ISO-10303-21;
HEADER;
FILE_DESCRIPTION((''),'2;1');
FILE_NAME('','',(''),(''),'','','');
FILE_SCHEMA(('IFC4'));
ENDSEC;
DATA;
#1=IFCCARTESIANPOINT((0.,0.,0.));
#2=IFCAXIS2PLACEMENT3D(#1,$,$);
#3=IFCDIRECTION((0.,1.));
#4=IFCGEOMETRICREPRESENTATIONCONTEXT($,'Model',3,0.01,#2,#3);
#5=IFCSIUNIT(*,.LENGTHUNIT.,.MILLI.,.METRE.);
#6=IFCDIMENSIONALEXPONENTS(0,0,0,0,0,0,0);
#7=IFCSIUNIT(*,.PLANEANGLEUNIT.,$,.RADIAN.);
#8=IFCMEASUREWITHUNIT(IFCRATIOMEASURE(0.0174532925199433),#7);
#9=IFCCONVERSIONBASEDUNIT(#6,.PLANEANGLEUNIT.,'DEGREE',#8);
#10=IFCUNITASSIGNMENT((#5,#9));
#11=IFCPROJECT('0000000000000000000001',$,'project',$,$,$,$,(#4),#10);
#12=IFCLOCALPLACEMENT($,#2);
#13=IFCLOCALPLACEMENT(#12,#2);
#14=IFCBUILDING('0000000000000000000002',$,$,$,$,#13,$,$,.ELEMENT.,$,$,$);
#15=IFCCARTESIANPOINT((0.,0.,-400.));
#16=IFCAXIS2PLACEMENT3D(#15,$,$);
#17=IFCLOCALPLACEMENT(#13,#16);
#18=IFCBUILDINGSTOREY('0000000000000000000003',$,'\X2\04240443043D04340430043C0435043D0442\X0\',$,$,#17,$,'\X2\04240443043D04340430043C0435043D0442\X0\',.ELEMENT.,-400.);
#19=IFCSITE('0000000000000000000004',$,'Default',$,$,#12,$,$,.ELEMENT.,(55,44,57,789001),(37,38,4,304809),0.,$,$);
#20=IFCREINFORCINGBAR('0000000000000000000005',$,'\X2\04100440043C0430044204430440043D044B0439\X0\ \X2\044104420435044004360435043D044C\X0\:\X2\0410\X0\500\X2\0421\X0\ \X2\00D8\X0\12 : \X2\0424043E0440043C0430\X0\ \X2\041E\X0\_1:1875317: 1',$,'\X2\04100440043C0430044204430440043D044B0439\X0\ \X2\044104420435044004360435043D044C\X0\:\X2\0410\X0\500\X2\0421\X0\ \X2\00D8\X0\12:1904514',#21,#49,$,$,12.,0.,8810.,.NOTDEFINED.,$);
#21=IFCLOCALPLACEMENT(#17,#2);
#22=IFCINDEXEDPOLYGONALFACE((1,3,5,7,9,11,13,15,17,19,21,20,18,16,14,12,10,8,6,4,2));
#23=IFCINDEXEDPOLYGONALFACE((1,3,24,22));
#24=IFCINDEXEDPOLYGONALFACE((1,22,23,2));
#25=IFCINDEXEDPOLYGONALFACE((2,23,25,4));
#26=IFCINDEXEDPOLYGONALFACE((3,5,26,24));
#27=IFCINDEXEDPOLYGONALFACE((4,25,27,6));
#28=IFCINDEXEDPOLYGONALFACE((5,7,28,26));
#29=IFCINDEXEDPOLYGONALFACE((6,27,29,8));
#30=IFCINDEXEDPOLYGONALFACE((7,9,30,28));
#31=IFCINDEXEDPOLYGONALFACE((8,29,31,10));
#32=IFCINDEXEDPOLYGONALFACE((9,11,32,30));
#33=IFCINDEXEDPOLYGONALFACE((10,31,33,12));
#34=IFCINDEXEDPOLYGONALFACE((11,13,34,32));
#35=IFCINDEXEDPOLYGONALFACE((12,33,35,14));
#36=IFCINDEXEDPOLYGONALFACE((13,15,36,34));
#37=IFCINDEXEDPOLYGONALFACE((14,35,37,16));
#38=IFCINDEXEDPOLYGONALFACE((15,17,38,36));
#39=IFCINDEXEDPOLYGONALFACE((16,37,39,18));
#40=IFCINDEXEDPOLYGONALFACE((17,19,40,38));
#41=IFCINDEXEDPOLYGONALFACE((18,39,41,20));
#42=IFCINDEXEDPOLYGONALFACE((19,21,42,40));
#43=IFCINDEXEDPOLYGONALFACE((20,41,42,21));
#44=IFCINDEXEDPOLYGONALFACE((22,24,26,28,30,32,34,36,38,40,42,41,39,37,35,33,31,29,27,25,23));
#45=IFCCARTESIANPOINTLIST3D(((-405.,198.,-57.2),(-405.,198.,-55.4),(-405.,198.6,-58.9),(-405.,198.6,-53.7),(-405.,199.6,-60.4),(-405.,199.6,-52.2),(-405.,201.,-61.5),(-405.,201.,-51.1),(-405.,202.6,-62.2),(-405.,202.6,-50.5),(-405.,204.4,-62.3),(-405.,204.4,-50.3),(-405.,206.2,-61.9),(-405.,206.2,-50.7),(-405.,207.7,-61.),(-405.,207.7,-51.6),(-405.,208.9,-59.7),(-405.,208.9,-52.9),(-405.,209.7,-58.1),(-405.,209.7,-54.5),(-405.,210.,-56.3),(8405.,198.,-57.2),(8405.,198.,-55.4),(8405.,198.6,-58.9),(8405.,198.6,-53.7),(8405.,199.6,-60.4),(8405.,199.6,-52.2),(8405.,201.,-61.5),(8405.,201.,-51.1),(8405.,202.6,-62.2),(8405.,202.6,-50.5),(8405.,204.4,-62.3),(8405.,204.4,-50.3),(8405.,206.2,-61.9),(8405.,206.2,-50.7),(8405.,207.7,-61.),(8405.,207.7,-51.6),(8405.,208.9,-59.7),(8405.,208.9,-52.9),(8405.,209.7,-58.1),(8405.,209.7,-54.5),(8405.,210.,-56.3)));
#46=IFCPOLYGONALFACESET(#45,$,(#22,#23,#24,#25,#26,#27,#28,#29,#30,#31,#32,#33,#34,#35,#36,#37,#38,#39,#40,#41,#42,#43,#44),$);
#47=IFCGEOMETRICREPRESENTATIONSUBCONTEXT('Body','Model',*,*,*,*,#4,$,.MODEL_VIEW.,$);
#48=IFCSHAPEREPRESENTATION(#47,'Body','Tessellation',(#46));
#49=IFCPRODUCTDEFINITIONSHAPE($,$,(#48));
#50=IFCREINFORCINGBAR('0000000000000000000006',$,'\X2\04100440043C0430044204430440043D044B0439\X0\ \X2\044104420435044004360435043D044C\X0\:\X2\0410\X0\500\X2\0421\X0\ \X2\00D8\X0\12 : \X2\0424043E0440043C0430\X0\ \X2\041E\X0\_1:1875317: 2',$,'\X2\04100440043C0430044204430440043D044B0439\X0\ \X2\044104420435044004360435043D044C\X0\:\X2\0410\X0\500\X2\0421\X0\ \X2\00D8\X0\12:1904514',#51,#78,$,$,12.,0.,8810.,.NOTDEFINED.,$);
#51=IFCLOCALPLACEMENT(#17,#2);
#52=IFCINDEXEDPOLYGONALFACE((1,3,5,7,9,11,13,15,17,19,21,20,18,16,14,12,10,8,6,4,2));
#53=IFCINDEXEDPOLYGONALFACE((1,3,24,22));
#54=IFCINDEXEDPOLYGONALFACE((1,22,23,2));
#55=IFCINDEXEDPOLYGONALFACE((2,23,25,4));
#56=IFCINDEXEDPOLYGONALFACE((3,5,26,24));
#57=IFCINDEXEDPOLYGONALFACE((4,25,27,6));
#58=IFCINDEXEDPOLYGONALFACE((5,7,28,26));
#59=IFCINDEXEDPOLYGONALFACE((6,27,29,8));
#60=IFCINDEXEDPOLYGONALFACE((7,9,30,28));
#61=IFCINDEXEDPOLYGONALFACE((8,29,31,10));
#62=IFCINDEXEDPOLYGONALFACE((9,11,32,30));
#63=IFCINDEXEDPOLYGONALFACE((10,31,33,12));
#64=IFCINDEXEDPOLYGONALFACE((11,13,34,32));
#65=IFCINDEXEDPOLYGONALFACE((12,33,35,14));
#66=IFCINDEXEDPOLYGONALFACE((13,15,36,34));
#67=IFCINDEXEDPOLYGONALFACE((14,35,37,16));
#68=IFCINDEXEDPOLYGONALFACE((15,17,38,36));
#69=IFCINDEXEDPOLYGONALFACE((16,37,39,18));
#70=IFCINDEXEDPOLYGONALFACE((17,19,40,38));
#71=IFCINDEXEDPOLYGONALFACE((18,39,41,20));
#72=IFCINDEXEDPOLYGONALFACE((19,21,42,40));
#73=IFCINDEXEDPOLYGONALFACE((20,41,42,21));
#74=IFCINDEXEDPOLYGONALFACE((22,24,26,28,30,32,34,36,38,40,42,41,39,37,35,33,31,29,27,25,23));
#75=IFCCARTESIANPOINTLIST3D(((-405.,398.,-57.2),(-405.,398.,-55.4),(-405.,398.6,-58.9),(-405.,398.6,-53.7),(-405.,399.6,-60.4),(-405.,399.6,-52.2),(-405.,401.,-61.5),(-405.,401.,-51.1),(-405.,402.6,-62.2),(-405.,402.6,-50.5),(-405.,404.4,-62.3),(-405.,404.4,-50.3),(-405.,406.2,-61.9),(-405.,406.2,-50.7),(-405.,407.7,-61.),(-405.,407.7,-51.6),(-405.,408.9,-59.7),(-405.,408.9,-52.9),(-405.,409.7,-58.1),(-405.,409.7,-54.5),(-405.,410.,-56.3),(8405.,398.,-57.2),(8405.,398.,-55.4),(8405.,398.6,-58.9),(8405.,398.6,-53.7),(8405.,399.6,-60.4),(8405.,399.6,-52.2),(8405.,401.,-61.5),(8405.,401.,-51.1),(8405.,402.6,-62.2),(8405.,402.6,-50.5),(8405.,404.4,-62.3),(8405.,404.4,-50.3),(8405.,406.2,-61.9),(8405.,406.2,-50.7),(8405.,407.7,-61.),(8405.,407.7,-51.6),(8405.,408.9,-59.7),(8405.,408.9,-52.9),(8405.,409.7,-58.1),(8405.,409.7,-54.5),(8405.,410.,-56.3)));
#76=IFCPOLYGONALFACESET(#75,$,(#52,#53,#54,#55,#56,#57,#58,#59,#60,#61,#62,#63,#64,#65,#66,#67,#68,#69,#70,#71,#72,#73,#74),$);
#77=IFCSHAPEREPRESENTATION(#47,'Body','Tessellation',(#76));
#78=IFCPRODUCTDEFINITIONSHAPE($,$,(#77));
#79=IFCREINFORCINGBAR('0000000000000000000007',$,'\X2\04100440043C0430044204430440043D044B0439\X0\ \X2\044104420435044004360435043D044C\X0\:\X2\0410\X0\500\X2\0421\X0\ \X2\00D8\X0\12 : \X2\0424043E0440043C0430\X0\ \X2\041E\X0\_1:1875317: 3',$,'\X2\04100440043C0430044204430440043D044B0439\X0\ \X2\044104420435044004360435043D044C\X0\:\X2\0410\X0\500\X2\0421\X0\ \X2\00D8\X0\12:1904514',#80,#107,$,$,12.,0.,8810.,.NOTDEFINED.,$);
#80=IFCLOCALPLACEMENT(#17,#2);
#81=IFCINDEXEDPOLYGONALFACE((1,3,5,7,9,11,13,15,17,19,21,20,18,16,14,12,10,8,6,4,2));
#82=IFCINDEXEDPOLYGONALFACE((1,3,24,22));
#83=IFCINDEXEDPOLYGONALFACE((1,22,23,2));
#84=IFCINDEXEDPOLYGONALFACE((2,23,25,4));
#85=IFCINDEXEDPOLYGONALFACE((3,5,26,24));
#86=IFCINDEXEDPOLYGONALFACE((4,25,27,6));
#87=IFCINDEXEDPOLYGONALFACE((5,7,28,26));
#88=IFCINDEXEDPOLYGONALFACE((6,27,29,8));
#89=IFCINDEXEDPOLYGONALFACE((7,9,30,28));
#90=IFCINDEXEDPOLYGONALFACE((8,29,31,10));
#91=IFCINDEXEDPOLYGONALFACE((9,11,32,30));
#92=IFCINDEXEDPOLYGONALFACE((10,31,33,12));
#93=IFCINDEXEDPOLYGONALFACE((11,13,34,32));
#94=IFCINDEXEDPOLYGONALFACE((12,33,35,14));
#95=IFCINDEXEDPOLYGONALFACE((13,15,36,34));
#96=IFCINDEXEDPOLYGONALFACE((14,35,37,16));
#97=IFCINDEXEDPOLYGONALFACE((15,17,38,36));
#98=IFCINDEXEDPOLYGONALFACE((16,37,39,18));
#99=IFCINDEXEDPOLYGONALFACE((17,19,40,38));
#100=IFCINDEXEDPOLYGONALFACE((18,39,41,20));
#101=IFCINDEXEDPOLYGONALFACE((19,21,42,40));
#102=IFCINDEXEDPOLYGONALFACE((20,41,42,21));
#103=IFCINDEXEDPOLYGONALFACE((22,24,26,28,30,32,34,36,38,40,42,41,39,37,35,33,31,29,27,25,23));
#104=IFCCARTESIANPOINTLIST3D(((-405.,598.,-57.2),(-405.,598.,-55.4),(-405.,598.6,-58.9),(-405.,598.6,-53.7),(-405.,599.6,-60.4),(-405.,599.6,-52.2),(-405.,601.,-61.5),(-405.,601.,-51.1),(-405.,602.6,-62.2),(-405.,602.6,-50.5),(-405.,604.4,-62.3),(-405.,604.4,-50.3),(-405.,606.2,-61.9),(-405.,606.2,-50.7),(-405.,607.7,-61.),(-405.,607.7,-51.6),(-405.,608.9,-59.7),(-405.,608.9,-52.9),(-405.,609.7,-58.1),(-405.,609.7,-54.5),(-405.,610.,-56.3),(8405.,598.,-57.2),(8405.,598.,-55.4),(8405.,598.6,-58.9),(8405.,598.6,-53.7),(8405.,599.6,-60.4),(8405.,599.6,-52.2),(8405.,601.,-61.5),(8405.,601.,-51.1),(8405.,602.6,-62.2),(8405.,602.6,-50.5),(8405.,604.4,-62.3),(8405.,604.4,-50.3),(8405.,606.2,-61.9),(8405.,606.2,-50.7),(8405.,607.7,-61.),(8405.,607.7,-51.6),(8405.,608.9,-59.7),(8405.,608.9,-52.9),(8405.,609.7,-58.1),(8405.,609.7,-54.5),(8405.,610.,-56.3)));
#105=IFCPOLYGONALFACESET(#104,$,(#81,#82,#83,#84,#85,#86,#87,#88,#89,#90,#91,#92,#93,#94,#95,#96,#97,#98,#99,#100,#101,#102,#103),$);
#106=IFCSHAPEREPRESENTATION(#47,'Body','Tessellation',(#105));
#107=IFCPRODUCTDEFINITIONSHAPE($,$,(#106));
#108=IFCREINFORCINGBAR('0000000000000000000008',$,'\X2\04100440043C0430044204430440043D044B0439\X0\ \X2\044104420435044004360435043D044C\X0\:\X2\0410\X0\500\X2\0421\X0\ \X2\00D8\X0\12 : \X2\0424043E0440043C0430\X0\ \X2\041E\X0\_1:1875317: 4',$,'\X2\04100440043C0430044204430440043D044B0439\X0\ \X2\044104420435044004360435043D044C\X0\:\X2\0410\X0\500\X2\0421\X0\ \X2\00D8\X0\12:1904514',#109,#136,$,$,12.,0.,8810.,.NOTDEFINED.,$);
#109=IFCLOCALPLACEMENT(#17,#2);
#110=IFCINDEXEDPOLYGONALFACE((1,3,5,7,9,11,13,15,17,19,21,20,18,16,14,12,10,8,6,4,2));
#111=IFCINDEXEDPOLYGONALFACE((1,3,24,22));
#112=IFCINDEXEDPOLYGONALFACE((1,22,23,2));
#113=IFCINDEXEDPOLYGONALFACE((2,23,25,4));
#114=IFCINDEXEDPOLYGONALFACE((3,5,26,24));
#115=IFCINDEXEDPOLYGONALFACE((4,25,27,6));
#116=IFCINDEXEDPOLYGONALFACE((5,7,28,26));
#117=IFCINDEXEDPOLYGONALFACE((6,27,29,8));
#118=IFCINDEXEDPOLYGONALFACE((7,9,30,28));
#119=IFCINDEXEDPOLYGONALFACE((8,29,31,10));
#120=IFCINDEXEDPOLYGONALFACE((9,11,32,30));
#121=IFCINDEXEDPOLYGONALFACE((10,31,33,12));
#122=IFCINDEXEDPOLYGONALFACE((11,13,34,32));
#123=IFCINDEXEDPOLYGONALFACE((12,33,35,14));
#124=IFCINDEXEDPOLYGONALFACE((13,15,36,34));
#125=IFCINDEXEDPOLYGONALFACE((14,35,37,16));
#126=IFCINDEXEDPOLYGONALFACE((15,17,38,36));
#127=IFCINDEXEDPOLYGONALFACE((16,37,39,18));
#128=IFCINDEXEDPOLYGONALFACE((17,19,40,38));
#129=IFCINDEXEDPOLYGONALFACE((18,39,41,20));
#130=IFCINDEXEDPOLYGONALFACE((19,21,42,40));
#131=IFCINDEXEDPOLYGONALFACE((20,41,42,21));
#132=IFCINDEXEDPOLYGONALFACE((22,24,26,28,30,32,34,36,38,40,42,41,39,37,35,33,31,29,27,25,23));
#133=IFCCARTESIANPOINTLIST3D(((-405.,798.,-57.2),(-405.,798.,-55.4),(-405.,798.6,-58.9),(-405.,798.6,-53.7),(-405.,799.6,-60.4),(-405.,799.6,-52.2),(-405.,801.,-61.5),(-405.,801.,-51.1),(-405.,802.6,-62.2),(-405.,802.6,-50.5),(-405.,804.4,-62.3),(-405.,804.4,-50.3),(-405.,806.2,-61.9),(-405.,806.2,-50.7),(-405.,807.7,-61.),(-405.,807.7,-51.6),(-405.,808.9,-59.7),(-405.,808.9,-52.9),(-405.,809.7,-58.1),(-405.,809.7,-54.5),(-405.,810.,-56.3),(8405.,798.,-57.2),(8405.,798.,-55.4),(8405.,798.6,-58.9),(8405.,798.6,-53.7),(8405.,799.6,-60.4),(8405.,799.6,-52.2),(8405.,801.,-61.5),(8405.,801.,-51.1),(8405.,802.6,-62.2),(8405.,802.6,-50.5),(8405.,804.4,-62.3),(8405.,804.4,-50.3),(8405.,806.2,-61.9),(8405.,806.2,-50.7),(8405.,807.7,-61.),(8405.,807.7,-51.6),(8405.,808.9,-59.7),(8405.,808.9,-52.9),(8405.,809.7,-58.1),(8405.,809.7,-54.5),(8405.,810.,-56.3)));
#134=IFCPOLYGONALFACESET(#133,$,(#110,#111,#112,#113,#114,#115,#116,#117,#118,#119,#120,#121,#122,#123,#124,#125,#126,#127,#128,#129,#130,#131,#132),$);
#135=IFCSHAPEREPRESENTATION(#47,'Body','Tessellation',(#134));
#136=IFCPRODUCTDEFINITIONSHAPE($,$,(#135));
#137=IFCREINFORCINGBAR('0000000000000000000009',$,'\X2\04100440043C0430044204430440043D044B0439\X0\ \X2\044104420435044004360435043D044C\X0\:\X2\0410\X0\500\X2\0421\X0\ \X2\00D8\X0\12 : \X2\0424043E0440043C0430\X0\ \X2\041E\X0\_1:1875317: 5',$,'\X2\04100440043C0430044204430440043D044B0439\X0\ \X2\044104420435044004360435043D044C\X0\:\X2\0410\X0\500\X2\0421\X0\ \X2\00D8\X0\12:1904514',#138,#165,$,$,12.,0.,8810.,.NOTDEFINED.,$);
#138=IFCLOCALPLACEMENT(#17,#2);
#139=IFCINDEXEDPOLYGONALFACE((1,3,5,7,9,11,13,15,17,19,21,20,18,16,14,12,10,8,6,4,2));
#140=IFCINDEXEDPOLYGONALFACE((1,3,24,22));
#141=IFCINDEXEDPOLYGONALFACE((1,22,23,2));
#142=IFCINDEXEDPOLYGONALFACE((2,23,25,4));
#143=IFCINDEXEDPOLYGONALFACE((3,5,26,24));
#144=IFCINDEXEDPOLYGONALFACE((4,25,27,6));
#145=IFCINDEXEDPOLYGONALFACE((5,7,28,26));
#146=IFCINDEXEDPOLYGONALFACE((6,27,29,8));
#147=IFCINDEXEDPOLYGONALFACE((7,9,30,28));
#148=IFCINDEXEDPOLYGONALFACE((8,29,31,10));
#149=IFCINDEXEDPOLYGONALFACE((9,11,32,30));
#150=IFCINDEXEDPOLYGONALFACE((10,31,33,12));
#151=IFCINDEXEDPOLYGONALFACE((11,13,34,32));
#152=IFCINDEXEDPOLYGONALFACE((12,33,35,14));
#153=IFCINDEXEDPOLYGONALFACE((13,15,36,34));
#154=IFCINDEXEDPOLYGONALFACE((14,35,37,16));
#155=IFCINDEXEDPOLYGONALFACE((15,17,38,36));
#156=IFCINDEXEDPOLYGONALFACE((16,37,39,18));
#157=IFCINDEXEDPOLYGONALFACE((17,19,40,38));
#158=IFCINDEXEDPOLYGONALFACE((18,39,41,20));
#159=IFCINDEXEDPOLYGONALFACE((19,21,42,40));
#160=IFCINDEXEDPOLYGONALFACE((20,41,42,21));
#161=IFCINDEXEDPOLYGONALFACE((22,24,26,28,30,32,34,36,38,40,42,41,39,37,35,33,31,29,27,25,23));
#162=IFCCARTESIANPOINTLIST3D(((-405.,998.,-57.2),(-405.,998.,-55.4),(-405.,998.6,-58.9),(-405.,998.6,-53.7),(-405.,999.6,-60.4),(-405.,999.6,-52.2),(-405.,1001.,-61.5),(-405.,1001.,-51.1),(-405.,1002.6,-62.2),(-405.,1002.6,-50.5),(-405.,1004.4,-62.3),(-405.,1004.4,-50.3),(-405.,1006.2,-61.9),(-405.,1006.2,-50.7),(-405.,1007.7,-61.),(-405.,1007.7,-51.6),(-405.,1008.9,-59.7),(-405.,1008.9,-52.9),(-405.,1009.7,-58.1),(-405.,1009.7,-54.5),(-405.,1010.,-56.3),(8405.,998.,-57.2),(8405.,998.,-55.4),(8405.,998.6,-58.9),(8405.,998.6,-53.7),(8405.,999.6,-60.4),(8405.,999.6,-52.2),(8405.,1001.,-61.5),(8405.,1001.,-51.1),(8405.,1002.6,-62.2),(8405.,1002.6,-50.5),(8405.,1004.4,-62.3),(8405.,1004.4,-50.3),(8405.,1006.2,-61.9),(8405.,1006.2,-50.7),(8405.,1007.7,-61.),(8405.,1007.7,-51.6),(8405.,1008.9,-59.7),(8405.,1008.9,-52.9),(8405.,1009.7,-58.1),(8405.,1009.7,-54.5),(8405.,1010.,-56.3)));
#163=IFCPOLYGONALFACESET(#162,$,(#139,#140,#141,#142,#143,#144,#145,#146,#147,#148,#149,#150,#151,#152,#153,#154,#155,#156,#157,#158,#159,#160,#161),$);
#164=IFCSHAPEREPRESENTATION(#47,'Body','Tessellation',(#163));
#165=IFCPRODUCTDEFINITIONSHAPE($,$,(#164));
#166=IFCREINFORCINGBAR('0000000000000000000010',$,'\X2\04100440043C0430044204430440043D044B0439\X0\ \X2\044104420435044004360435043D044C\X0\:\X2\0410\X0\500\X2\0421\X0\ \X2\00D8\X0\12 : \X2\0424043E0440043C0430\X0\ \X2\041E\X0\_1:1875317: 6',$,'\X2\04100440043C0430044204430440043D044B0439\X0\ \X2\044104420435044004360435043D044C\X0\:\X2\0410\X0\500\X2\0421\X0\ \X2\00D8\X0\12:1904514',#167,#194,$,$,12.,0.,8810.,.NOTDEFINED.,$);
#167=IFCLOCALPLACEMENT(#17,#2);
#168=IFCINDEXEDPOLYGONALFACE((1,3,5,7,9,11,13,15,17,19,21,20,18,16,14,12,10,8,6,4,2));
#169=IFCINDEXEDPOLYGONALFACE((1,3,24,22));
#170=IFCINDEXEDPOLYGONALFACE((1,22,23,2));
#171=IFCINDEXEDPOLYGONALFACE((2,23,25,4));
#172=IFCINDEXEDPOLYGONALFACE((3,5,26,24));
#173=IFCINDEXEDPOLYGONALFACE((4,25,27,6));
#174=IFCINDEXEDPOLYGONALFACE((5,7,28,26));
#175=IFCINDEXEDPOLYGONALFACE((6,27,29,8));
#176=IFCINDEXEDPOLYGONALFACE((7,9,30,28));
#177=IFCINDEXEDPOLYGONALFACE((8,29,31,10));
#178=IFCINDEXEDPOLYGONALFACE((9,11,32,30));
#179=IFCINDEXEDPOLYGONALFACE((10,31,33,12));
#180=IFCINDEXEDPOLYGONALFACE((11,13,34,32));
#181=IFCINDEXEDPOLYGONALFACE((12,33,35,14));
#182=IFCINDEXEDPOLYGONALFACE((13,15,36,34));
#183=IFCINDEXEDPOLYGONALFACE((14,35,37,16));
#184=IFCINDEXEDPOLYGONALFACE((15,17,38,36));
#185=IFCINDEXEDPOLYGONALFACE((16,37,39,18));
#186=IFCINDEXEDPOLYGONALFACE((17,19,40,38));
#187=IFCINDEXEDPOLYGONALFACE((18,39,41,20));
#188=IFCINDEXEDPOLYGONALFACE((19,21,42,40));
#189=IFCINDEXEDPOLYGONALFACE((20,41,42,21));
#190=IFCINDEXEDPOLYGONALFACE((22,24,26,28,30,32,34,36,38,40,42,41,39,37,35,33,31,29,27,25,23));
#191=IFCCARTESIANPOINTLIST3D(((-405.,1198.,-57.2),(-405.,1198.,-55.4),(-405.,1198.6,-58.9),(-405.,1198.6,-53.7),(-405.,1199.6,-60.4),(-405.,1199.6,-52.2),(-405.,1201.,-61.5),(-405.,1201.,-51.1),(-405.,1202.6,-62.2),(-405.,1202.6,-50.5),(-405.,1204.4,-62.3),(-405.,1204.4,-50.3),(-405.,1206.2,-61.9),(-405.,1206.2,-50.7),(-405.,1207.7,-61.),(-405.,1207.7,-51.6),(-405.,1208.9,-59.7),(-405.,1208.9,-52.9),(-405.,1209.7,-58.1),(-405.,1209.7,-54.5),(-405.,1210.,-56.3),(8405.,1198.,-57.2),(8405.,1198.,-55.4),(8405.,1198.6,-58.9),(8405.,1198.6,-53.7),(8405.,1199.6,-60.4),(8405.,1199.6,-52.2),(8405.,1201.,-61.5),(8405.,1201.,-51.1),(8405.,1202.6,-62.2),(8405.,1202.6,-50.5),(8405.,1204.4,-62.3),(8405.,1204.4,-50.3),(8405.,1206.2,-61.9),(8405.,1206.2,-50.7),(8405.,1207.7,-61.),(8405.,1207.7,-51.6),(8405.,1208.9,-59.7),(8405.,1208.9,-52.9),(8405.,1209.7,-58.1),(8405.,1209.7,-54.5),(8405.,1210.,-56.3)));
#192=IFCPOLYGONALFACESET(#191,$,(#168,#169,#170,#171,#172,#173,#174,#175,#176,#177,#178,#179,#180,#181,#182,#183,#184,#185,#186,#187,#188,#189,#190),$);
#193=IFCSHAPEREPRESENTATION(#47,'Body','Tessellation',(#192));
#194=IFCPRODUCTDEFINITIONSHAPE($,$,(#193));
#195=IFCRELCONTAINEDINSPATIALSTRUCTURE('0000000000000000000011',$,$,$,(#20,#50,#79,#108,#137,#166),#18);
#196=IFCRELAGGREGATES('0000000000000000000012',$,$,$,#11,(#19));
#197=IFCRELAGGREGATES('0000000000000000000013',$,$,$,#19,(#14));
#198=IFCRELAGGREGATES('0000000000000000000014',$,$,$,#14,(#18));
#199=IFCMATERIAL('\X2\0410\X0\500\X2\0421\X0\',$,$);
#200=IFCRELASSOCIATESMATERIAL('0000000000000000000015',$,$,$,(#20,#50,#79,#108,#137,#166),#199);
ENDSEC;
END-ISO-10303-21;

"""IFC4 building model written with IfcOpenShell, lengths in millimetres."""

from ifc_helpers import new_model, entity, si_unit, converted_unit, direction, frame, origin, place, context, subcontext, project, spatial, material, element, save


model = new_model("IFC4")

# Units and contexts
model_context = context("Model", 3, precision=0.01, world=origin(), true_north=direction((0.0, 1.0)))
body_context = subcontext(model_context, "Body", "Model", "MODEL_VIEW")
ifc_project = project(units=[si_unit("LENGTHUNIT", "METRE", prefix="MILLI"), converted_unit("PLANEANGLEUNIT", "DEGREE", entity("IfcRatioMeasure", 0.0174532925199433), si_unit("PLANEANGLEUNIT", "RADIAN"), dimensions=[0, 0, 0, 0, 0, 0, 0])], contexts=[model_context])

# Site, building, storey
site_placement = place(None, origin())
site = spatial("IfcSite", under=ifc_project, at=site_placement, Name="Default", CompositionType="ELEMENT", RefLatitude=(55, 44, 57, 789001), RefLongitude=(37, 38, 4, 304809), RefElevation=0.0)
building_placement = place(site_placement, origin())
building = spatial("IfcBuilding", under=site, at=building_placement, CompositionType="ELEMENT")
storey_placement = place(building_placement, frame((0.0, 0.0, -400.0)))
storey = spatial("IfcBuildingStorey", under=building, at=storey_placement, Name="Фундамент", LongName="Фундамент", CompositionType="ELEMENT", Elevation=-400.0)

# Reinforcing bars
ifc_material = material(Name="А500С")
reinforcing_bar_1_placement = place(storey_placement, origin())
element("IfcReinforcingBar", 1, at=reinforcing_bar_1_placement, inside=storey, material=ifc_material, Name="Арматурный стержень:А500С Ø12 : Форма О_1:1875317: 1", ObjectType="Арматурный стержень:А500С Ø12:1904514", BarLength=8810.0, CrossSectionArea=0.0, NominalDiameter=12.0, PredefinedType="NOTDEFINED", context=body_context, shape_type="AdvancedSweptSolid", body=[
    entity("IfcSweptDiskSolid", entity("IfcCompositeCurve", [entity("IfcCompositeCurveSegment", "CONTINUOUS", True, entity("IfcPolyline", [entity("IfcCartesianPoint", [-405.0, 204.0, -56.3]), entity("IfcCartesianPoint", [8405.0, 204.0, -56.3])]))], False), 6.0, None, 0.0, 1.0),
])
reinforcing_bar_2_placement = place(storey_placement, origin())
element("IfcReinforcingBar", 2, at=reinforcing_bar_2_placement, inside=storey, material=ifc_material, Name="Арматурный стержень:А500С Ø12 : Форма О_1:1875317: 2", ObjectType="Арматурный стержень:А500С Ø12:1904514", BarLength=8810.0, CrossSectionArea=0.0, NominalDiameter=12.0, PredefinedType="NOTDEFINED", context=body_context, shape_type="AdvancedSweptSolid", body=[
    entity("IfcSweptDiskSolid", entity("IfcCompositeCurve", [entity("IfcCompositeCurveSegment", "CONTINUOUS", True, entity("IfcPolyline", [entity("IfcCartesianPoint", [-405.0, 404.0, -56.3]), entity("IfcCartesianPoint", [8405.0, 404.0, -56.3])]))], False), 6.0, None, 0.0, 1.0),
])
reinforcing_bar_3_placement = place(storey_placement, origin())
element("IfcReinforcingBar", 3, at=reinforcing_bar_3_placement, inside=storey, material=ifc_material, Name="Арматурный стержень:А500С Ø12 : Форма О_1:1875317: 3", ObjectType="Арматурный стержень:А500С Ø12:1904514", BarLength=8810.0, CrossSectionArea=0.0, NominalDiameter=12.0, PredefinedType="NOTDEFINED", context=body_context, shape_type="AdvancedSweptSolid", body=[
    entity("IfcSweptDiskSolid", entity("IfcCompositeCurve", [entity("IfcCompositeCurveSegment", "CONTINUOUS", True, entity("IfcPolyline", [entity("IfcCartesianPoint", [-405.0, 604.0, -56.3]), entity("IfcCartesianPoint", [8405.0, 604.0, -56.3])]))], False), 6.0, None, 0.0, 1.0),
])
reinforcing_bar_4_placement = place(storey_placement, origin())
element("IfcReinforcingBar", 4, at=reinforcing_bar_4_placement, inside=storey, material=ifc_material, Name="Арматурный стержень:А500С Ø12 : Форма О_1:1875317: 4", ObjectType="Арматурный стержень:А500С Ø12:1904514", BarLength=8810.0, CrossSectionArea=0.0, NominalDiameter=12.0, PredefinedType="NOTDEFINED", context=body_context, shape_type="AdvancedSweptSolid", body=[
    entity("IfcSweptDiskSolid", entity("IfcCompositeCurve", [entity("IfcCompositeCurveSegment", "CONTINUOUS", True, entity("IfcPolyline", [entity("IfcCartesianPoint", [-405.0, 804.0, -56.3]), entity("IfcCartesianPoint", [8405.0, 804.0, -56.3])]))], False), 6.0, None, 0.0, 1.0),
])
reinforcing_bar_5_placement = place(storey_placement, origin())
element("IfcReinforcingBar", 5, at=reinforcing_bar_5_placement, inside=storey, material=ifc_material, Name="Арматурный стержень:А500С Ø12 : Форма О_1:1875317: 5", ObjectType="Арматурный стержень:А500С Ø12:1904514", BarLength=8810.0, CrossSectionArea=0.0, NominalDiameter=12.0, PredefinedType="NOTDEFINED", context=body_context, shape_type="AdvancedSweptSolid", body=[
    entity("IfcSweptDiskSolid", entity("IfcCompositeCurve", [entity("IfcCompositeCurveSegment", "CONTINUOUS", True, entity("IfcPolyline", [entity("IfcCartesianPoint", [-405.0, 1004.0, -56.3]), entity("IfcCartesianPoint", [8405.0, 1004.0, -56.3])]))], False), 6.0, None, 0.0, 1.0),
])
reinforcing_bar_6_placement = place(storey_placement, origin())
element("IfcReinforcingBar", 6, at=reinforcing_bar_6_placement, inside=storey, material=ifc_material, Name="Арматурный стержень:А500С Ø12 : Форма О_1:1875317: 6", ObjectType="Арматурный стержень:А500С Ø12:1904514", BarLength=8810.0, CrossSectionArea=0.0, NominalDiameter=12.0, PredefinedType="NOTDEFINED", context=body_context, shape_type="AdvancedSweptSolid", body=[
    entity("IfcSweptDiskSolid", entity("IfcCompositeCurve", [entity("IfcCompositeCurveSegment", "CONTINUOUS", True, entity("IfcPolyline", [entity("IfcCartesianPoint", [-405.0, 1204.0, -56.3]), entity("IfcCartesianPoint", [8405.0, 1204.0, -56.3])]))], False), 6.0, None, 0.0, 1.0),
])

save(model, "model.ifc")
